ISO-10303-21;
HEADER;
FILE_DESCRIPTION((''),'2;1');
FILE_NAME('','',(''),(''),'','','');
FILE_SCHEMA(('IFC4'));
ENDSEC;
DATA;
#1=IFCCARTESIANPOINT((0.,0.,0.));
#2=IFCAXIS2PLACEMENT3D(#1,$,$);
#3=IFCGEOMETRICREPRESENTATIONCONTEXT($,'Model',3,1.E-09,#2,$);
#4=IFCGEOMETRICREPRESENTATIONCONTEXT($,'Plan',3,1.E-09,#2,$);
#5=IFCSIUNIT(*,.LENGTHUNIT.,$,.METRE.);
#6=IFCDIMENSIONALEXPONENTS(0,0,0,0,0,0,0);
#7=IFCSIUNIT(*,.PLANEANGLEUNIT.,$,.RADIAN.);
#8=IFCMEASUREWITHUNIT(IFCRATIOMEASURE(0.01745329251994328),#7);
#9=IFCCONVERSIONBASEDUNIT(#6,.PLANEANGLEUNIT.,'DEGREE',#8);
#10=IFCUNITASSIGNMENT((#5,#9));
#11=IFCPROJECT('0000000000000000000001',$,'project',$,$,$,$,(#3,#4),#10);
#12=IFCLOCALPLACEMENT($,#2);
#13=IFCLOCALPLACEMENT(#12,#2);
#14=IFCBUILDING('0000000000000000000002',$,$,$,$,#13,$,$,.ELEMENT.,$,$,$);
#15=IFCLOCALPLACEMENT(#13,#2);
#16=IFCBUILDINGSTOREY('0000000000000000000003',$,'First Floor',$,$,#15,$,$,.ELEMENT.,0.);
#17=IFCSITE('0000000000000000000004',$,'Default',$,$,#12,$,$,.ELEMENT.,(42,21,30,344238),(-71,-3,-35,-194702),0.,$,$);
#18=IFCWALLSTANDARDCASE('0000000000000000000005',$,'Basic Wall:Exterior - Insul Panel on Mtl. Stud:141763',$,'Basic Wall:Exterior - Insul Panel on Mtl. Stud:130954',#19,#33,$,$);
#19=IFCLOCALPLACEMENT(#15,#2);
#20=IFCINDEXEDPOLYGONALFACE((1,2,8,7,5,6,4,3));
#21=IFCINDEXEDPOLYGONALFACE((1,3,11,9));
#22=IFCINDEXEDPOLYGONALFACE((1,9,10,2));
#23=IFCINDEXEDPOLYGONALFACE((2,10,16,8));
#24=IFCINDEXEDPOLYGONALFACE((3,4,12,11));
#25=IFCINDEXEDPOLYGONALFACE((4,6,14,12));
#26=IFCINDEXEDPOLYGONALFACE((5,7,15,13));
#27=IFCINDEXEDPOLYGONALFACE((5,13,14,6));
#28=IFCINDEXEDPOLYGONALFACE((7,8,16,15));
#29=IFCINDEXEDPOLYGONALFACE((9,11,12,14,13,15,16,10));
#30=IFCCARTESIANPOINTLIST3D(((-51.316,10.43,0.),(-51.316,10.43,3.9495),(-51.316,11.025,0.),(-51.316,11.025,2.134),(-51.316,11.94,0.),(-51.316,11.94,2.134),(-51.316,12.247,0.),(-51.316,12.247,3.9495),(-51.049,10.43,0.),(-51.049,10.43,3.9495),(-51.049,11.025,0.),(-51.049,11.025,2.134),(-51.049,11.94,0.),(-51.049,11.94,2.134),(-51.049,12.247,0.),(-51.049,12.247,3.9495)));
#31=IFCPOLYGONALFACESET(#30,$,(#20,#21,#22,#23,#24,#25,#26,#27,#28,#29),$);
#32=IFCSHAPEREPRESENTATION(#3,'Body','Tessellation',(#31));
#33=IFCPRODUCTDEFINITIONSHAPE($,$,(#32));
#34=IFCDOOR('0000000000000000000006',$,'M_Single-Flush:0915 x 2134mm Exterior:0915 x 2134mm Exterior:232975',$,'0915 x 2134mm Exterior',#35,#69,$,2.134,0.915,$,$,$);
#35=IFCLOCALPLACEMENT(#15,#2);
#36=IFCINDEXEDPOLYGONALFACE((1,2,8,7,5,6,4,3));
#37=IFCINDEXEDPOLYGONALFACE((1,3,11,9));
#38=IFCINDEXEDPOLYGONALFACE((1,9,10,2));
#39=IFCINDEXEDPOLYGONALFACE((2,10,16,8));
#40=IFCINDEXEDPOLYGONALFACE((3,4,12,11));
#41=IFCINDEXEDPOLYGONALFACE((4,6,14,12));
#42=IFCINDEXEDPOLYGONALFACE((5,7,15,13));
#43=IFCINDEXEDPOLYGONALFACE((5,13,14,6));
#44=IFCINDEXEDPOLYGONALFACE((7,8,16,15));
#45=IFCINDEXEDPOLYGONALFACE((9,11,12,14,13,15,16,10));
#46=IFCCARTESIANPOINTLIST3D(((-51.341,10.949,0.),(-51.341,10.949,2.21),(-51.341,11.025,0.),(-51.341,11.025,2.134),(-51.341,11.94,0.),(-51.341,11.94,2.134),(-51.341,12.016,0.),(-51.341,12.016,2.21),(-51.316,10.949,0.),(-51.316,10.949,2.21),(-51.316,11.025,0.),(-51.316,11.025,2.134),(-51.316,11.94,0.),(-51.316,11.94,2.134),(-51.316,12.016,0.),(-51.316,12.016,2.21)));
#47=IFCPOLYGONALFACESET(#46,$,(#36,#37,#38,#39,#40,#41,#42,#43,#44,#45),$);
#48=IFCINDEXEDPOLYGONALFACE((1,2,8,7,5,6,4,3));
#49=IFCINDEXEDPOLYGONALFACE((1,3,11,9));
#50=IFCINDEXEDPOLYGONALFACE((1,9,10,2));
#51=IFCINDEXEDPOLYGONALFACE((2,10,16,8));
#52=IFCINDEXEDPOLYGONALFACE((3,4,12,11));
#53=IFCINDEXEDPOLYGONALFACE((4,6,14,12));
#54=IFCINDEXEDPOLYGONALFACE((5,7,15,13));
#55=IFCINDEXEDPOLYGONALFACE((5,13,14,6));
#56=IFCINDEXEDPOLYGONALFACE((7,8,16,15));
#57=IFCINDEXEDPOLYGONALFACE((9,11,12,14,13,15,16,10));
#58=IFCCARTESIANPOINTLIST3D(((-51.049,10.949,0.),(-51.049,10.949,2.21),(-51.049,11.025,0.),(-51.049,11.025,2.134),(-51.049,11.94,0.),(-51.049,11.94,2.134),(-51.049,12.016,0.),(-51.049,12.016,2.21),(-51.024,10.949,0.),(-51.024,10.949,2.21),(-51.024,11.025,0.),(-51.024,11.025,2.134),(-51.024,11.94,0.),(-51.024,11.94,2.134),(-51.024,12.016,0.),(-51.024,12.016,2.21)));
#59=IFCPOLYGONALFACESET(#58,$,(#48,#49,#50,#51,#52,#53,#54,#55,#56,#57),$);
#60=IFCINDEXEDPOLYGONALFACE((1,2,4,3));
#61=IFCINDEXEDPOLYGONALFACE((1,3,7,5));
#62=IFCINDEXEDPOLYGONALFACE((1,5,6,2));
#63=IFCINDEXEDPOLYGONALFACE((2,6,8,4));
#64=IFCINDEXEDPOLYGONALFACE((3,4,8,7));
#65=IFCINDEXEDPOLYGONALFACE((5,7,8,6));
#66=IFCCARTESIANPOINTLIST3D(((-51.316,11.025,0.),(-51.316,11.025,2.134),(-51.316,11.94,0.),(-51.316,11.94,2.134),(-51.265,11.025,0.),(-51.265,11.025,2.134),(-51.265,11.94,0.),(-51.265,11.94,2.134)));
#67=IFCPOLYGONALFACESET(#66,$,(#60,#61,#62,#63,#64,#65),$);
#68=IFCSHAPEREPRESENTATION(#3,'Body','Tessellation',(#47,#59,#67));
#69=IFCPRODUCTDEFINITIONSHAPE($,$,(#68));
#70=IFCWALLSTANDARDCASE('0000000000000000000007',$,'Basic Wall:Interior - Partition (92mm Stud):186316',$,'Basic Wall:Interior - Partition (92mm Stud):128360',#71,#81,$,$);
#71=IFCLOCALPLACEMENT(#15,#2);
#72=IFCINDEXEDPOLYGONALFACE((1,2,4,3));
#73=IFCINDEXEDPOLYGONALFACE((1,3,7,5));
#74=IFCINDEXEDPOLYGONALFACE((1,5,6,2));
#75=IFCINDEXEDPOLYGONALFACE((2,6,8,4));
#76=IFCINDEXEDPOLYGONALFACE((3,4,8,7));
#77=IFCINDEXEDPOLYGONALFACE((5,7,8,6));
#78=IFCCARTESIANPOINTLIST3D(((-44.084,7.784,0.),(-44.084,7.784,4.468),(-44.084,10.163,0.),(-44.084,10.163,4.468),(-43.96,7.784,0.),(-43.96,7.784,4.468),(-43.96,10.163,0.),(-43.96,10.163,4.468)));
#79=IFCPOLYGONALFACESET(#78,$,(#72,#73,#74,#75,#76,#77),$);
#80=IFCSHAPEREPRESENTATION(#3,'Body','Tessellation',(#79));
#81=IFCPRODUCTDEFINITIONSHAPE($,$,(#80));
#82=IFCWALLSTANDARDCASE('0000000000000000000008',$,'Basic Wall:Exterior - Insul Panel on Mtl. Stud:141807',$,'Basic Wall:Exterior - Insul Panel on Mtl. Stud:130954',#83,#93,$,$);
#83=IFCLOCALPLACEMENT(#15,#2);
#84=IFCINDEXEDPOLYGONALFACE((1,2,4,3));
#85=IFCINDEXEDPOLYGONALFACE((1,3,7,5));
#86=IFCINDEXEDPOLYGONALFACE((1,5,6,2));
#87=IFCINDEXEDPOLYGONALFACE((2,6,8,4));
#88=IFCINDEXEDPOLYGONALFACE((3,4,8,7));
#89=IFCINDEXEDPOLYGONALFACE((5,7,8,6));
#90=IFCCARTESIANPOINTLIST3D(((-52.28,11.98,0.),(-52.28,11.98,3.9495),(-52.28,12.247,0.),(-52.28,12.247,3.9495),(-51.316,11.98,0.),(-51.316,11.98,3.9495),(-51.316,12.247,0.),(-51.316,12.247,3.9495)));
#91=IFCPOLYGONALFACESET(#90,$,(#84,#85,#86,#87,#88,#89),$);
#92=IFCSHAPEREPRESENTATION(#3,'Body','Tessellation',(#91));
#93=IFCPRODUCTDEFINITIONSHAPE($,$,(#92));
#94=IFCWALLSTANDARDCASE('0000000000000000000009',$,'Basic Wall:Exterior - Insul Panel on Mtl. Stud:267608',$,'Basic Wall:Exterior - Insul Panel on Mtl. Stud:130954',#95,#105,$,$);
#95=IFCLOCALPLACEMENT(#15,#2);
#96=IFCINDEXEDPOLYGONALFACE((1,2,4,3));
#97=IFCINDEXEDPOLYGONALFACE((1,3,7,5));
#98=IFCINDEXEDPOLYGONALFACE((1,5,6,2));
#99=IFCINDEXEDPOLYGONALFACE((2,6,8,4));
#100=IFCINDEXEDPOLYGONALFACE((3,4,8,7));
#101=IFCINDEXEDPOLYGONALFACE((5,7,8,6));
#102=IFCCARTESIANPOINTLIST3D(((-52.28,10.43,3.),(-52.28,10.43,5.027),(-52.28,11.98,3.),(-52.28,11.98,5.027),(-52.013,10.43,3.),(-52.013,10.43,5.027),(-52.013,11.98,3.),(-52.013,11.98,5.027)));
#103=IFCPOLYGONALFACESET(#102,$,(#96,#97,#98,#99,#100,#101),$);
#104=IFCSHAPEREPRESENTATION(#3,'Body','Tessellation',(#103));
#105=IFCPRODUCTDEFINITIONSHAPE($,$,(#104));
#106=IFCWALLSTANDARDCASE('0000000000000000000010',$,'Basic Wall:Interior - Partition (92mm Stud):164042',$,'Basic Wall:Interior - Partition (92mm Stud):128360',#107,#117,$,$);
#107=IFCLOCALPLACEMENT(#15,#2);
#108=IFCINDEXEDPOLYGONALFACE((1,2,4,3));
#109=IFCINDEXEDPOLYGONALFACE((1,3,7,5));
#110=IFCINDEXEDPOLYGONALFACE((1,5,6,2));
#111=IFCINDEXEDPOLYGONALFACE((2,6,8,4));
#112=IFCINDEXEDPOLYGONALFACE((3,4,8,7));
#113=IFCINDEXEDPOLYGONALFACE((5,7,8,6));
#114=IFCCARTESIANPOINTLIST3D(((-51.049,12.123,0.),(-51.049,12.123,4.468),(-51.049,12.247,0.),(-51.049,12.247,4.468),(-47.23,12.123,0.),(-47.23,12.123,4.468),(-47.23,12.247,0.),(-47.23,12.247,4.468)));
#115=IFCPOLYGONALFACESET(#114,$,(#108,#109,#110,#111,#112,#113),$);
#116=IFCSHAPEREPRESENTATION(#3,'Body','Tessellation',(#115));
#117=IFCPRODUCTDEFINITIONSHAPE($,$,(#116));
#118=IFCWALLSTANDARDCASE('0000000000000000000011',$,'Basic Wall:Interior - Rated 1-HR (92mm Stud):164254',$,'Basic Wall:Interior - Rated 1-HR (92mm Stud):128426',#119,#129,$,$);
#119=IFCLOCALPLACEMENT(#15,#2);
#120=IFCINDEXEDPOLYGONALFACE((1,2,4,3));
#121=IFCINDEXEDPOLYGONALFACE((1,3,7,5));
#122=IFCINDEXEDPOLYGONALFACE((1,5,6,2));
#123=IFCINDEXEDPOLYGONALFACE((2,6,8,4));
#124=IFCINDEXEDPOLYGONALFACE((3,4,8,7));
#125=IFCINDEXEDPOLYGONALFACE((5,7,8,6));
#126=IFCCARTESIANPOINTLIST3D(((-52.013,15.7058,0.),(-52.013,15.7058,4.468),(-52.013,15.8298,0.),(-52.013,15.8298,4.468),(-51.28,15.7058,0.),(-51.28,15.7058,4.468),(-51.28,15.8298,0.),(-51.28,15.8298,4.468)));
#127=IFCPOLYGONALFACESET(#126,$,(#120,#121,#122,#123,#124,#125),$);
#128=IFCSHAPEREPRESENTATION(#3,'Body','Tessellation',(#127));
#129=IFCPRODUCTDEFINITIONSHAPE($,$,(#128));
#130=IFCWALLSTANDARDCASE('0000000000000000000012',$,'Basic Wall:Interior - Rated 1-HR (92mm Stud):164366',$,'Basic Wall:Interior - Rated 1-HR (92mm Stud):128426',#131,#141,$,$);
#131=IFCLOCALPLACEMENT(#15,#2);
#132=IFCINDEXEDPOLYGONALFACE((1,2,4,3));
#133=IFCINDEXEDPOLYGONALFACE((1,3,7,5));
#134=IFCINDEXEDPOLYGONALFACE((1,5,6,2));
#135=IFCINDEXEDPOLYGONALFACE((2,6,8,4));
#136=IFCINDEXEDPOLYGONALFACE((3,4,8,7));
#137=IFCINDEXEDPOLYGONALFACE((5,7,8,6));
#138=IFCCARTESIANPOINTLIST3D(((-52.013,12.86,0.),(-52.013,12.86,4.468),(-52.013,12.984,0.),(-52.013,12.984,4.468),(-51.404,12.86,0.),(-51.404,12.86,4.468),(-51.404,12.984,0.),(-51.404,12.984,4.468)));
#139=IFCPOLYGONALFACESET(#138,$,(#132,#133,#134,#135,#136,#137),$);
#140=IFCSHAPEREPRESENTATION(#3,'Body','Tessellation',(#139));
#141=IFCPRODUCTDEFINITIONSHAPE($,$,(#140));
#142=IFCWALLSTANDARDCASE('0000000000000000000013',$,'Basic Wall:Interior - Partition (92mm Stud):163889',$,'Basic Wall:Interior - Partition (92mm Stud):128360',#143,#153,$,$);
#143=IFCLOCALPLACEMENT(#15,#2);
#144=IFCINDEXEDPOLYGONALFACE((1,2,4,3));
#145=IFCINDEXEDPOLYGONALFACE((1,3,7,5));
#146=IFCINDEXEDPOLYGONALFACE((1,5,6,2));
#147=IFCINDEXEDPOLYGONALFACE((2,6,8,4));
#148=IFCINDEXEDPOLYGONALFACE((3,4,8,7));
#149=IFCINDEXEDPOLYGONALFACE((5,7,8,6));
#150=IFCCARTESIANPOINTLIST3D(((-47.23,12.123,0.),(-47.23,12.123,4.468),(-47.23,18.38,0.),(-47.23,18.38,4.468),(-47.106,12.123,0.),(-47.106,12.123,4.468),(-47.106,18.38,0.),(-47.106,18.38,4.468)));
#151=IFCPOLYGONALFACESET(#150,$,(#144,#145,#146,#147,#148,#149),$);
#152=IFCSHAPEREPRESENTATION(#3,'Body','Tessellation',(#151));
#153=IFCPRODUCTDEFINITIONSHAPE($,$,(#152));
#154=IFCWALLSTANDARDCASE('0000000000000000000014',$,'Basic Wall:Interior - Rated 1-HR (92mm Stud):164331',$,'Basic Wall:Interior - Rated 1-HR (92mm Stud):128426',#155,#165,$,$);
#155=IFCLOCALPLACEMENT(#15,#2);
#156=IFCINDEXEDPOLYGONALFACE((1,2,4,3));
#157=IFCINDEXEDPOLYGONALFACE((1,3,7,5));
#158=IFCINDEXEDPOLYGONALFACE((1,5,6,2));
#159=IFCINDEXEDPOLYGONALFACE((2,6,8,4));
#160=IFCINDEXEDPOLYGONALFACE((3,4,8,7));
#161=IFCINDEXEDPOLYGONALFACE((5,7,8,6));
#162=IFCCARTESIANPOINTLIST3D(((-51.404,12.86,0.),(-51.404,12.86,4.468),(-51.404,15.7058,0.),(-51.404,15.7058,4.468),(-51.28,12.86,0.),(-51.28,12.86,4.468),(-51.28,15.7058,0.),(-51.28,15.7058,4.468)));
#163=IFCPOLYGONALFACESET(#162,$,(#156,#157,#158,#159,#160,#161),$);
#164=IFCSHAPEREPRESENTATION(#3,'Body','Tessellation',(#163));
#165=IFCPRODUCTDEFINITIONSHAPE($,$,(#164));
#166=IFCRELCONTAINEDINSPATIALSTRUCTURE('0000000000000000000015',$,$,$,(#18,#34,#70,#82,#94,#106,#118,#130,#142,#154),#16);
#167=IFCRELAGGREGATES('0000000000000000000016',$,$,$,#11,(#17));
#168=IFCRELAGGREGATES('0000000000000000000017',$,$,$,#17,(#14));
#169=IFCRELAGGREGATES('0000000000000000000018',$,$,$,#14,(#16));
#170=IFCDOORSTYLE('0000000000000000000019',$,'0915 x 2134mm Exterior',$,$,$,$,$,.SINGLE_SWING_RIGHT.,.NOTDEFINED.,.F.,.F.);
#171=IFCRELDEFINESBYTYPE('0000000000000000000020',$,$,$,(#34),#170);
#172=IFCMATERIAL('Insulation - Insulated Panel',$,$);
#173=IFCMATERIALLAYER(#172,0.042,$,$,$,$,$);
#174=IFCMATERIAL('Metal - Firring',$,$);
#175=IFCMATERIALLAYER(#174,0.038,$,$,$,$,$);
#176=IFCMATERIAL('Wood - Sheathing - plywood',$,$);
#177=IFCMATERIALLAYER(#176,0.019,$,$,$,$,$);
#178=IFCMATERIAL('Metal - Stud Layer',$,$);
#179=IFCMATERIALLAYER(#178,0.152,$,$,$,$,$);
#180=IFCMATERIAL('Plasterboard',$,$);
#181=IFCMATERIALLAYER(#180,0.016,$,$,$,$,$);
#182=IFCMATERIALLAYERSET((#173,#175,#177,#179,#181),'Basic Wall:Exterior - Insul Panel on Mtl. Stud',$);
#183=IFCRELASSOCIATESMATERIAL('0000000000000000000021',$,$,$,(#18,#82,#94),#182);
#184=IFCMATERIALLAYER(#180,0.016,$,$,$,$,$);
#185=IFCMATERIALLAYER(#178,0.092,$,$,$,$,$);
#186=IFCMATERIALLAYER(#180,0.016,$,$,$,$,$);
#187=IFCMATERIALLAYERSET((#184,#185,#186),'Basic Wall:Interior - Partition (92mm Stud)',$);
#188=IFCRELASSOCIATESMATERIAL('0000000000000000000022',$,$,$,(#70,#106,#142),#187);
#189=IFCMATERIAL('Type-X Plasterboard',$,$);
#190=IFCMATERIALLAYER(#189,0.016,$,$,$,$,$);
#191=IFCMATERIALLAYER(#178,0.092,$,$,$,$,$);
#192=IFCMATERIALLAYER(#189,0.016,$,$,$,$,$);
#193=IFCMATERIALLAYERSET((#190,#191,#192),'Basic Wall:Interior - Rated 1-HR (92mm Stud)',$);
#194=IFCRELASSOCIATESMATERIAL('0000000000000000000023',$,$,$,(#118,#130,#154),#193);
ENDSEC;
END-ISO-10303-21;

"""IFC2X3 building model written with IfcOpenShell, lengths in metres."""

from ifc_helpers import new_model, entity, si_unit, converted_unit, frame, frame_2d, origin, origin_2d_with_axis, place, context, project, spatial, polyline, rectangle, outline, extrude, source, transform, mapped, material, layer, layer_set, layer_usage, type_object, type_shapes, element, fill, save


model = new_model("IFC2X3")

# Units and contexts
model_context = context("Model", 3, precision=1e-09, world=origin())
plan_context = context("Plan", 3, precision=1e-09, world=origin())
ifc_project = project(units=[si_unit("LENGTHUNIT", "METRE"), converted_unit("PLANEANGLEUNIT", "DEGREE", entity("IfcRatioMeasure", 0.01745329251994328), si_unit("PLANEANGLEUNIT", "RADIAN"), dimensions=[0, 0, 0, 0, 0, 0, 0])], contexts=[model_context, plan_context])

# Site, building, storey
site_placement = place(None, origin())
site = spatial("IfcSite", under=ifc_project, at=site_placement, Name="Default", CompositionType="ELEMENT", RefLatitude=(42, 21, 30, 344238), RefLongitude=(-71, -3, -35, -194702), RefElevation=0.0)
building_placement = place(site_placement, origin())
building = spatial("IfcBuilding", under=site, at=building_placement, CompositionType="ELEMENT")
storey_placement = place(building_placement, origin())
storey = spatial("IfcBuildingStorey", under=building, at=storey_placement, Name="First Floor", CompositionType="ELEMENT", Elevation=0.0)

# Shared definitions
ifc_material_1 = material(Name="Insulation - Insulated Panel")
ifc_layer_1 = layer(ifc_material_1, 0.042)
ifc_material_2 = material(Name="Metal - Firring")
ifc_layer_2 = layer(ifc_material_2, 0.038)
ifc_material_3 = material(Name="Wood - Sheathing - plywood")
ifc_layer_3 = layer(ifc_material_3, 0.019)
ifc_material_4 = material(Name="Metal - Stud Layer")
ifc_layer_4 = layer(ifc_material_4, 0.152)
ifc_material_5 = material(Name="Plasterboard")
ifc_layer_5 = layer(ifc_material_5, 0.016)
ifc_layer_set_1 = layer_set([ifc_layer_1, ifc_layer_2, ifc_layer_3, ifc_layer_4, ifc_layer_5], Name="Basic Wall:Exterior - Insul Panel on Mtl. Stud")
ifc_layer_usage_1 = layer_usage(ifc_layer_set_1, "AXIS2", "NEGATIVE", 0.1335)

# Shared definitions
ifc_layer_6 = layer(ifc_material_5, 0.016)
ifc_layer_7 = layer(ifc_material_4, 0.092)
ifc_layer_8 = layer(ifc_material_5, 0.016)
ifc_layer_set_2 = layer_set([ifc_layer_6, ifc_layer_7, ifc_layer_8], Name="Basic Wall:Interior - Partition (92mm Stud)")
ifc_layer_usage_2 = layer_usage(ifc_layer_set_2, "AXIS2", "NEGATIVE", 0.062)

# Wall, opening, door
wall_1_placement = place(storey_placement, frame((-51.1825, 10.43, 0.0), z_axis=(0.0, 0.0, 1.0), x_axis=(0.0, 1.0, 0.0)))
wall_1 = element("IfcWallStandardCase", 1, at=wall_1_placement, inside=storey, material=ifc_layer_usage_1, Name="Basic Wall:Exterior - Insul Panel on Mtl. Stud:141763", ObjectType="Basic Wall:Exterior - Insul Panel on Mtl. Stud:130954", context=model_context, shape_type="SweptSolid", body=[
    extrude(rectangle(XDim=1.817, YDim=0.267, at=frame_2d((0.9085, 0.0), x_axis=(-1.0, 0.0))), origin(), (0.0, 0.0, 1.0), 3.9495),
])
opening_1_placement = place(wall_1_placement, frame((0.595, -0.1335, 0.0)))
opening_1 = element("IfcOpeningElement", 2, at=opening_1_placement, cuts=wall_1, ObjectType="Opening", context=model_context, shape_type="SweptSolid", body=[
    extrude(rectangle(XDim=0.915, YDim=2.134, at=frame_2d((1.067, 0.4575), x_axis=(0.0, 1.0))), frame((0.0, 0.0, 0.0), z_axis=(0.0, 1.0, 0.0), x_axis=(0.0, 0.0, 1.0)), (0.0, 0.0, 1.0), 0.267),
])
door_style_1 = type_object("IfcDoorStyle", Name="0915 x 2134mm Exterior", ConstructionType="NOTDEFINED", OperationType="SINGLE_SWING_RIGHT", ParameterTakesPrecedence=False, Sizeable=False)
shared_shape_1 = source(origin(), model_context, "Body", "SweptSolid", [
    extrude(outline(polyline([(-0.5335, -1.124), (0.5335, -1.124), (0.5335, 1.086), (0.4575, 1.086), (0.4575, -1.048), (-0.4575, -1.048), (-0.4575, 1.086), (-0.5335, 1.086), (-0.5335, -1.124)])), frame((0.4575, 0.267, 1.086), z_axis=(0.0, 1.0, 0.0), x_axis=(1.0, 0.0, 0.0)), (0.0, 0.0, 1.0), 0.025),
    extrude(outline(polyline([(-1.124, -0.5335), (1.086, -0.5335), (1.086, -0.4575), (-1.048, -0.4575), (-1.048, 0.4575), (1.086, 0.4575), (1.086, 0.5335), (-1.124, 0.5335), (-1.124, -0.5335)])), frame((0.4575, -0.025, 1.086), z_axis=(0.0, 1.0, 0.0), x_axis=(0.0, 0.0, -1.0)), (0.0, 0.0, 1.0), 0.025),
    extrude(rectangle(XDim=0.051, YDim=0.915, at=origin_2d_with_axis()), frame((0.4575, 0.2415, 0.0), z_axis=(0.0, 0.0, 1.0), x_axis=(0.0, 1.0, 0.0)), (0.0, 0.0, 1.0), 2.134),
])
type_shapes(door_style_1, [shared_shape_1])
door_1_placement = place(opening_1_placement, origin())
door_1 = element("IfcDoor", 3, at=door_1_placement, inside=storey, type_object=door_style_1, Name="M_Single-Flush:0915 x 2134mm Exterior:0915 x 2134mm Exterior:232975", ObjectType="0915 x 2134mm Exterior", OverallHeight=2.134, OverallWidth=0.915, context=model_context, shape_type="MappedRepresentation", body=[
    mapped(shared_shape_1, transform((0.0, 0.0, 0.0), scale=1.0)),
])
fill(opening_1, door_1)

# Walls
wall_2_placement = place(storey_placement, frame((-44.022, 10.163, 0.0), z_axis=(0.0, 0.0, 1.0), x_axis=(0.0, -1.0, 0.0)))
element("IfcWallStandardCase", 4, at=wall_2_placement, inside=storey, material=ifc_layer_usage_2, Name="Basic Wall:Interior - Partition (92mm Stud):186316", ObjectType="Basic Wall:Interior - Partition (92mm Stud):128360", context=model_context, shape_type="SweptSolid", body=[
    extrude(rectangle(XDim=2.379, YDim=0.124, at=frame_2d((1.1895, 0.0), x_axis=(-1.0, 0.0))), origin(), (0.0, 0.0, 1.0), 4.468),
])
wall_3_placement = place(storey_placement, frame((-51.316, 12.1135, 0.0), z_axis=(0.0, 0.0, 1.0), x_axis=(-1.0, 0.0, 0.0)))
element("IfcWallStandardCase", 5, at=wall_3_placement, inside=storey, material=ifc_layer_usage_1, Name="Basic Wall:Exterior - Insul Panel on Mtl. Stud:141807", ObjectType="Basic Wall:Exterior - Insul Panel on Mtl. Stud:130954", context=model_context, shape_type="SweptSolid", body=[
    extrude(rectangle(XDim=0.964, YDim=0.267, at=frame_2d((0.482, 0.0), x_axis=(-1.0, 0.0))), origin(), (0.0, 0.0, 1.0), 3.9495),
])
wall_4_placement = place(storey_placement, frame((-52.1465, 10.2965, 3.0), z_axis=(0.0, 0.0, 1.0), x_axis=(0.0, 1.0, 0.0)))
element("IfcWallStandardCase", 6, at=wall_4_placement, inside=storey, material=ifc_layer_usage_1, Name="Basic Wall:Exterior - Insul Panel on Mtl. Stud:267608", ObjectType="Basic Wall:Exterior - Insul Panel on Mtl. Stud:130954", context=model_context, shape_type="SweptSolid", body=[
    extrude(rectangle(XDim=1.55, YDim=0.267, at=frame_2d((0.9085, 0.0), x_axis=(-1.0, 0.0))), origin(), (0.0, 0.0, 1.0), 2.027),
])
wall_5_placement = place(storey_placement, frame((-51.049, 12.185, 0.0)))
element("IfcWallStandardCase", 7, at=wall_5_placement, inside=storey, material=ifc_layer_usage_2, Name="Basic Wall:Interior - Partition (92mm Stud):164042", ObjectType="Basic Wall:Interior - Partition (92mm Stud):128360", context=model_context, shape_type="SweptSolid", body=[
    extrude(rectangle(XDim=3.819, YDim=0.124, at=frame_2d((1.9095, 0.0), x_axis=(-1.0, 0.0))), origin(), (0.0, 0.0, 1.0), 4.468),
])
ifc_material_6 = material(Name="Type-X Plasterboard")
ifc_layer_9 = layer(ifc_material_6, 0.016)
ifc_layer_10 = layer(ifc_material_4, 0.092)
ifc_layer_11 = layer(ifc_material_6, 0.016)
ifc_layer_set_3 = layer_set([ifc_layer_9, ifc_layer_10, ifc_layer_11], Name="Basic Wall:Interior - Rated 1-HR (92mm Stud)")
ifc_layer_usage_3 = layer_usage(ifc_layer_set_3, "AXIS2", "NEGATIVE", 0.062)
wall_6_placement = place(storey_placement, frame((-52.013, 15.7678, 0.0)))
element("IfcWallStandardCase", 8, at=wall_6_placement, inside=storey, material=ifc_layer_usage_3, Name="Basic Wall:Interior - Rated 1-HR (92mm Stud):164254", ObjectType="Basic Wall:Interior - Rated 1-HR (92mm Stud):128426", context=model_context, shape_type="SweptSolid", body=[
    extrude(rectangle(XDim=0.733, YDim=0.124, at=frame_2d((0.3665, 0.0), x_axis=(-1.0, 0.0))), origin(), (0.0, 0.0, 1.0), 4.468),
])
wall_7_placement = place(storey_placement, frame((-51.404, 12.922, 0.0), z_axis=(0.0, 0.0, 1.0), x_axis=(-1.0, 0.0, 0.0)))
element("IfcWallStandardCase", 9, at=wall_7_placement, inside=storey, material=ifc_layer_usage_3, Name="Basic Wall:Interior - Rated 1-HR (92mm Stud):164366", ObjectType="Basic Wall:Interior - Rated 1-HR (92mm Stud):128426", context=model_context, shape_type="SweptSolid", body=[
    extrude(rectangle(XDim=0.609, YDim=0.124, at=frame_2d((0.3045, 0.0), x_axis=(-1.0, 0.0))), origin(), (0.0, 0.0, 1.0), 4.468),
])
wall_8_placement = place(storey_placement, frame((-47.168, 12.123, 0.0), z_axis=(0.0, 0.0, 1.0), x_axis=(0.0, 1.0, 0.0)))
element("IfcWallStandardCase", 10, at=wall_8_placement, inside=storey, material=ifc_layer_usage_2, Name="Basic Wall:Interior - Partition (92mm Stud):163889", ObjectType="Basic Wall:Interior - Partition (92mm Stud):128360", context=model_context, shape_type="SweptSolid", body=[
    extrude(rectangle(XDim=6.257, YDim=0.124, at=frame_2d((3.1285, 0.0), x_axis=(-1.0, 0.0))), origin(), (0.0, 0.0, 1.0), 4.468),
])
wall_9_placement = place(storey_placement, frame((-51.342, 15.7058, 0.0), z_axis=(0.0, 0.0, 1.0), x_axis=(0.0, -1.0, 0.0)))
element("IfcWallStandardCase", 11, at=wall_9_placement, inside=storey, material=ifc_layer_usage_3, Name="Basic Wall:Interior - Rated 1-HR (92mm Stud):164331", ObjectType="Basic Wall:Interior - Rated 1-HR (92mm Stud):128426", context=model_context, shape_type="SweptSolid", body=[
    extrude(rectangle(XDim=2.8458, YDim=0.124, at=frame_2d((1.4229, 0.0), x_axis=(-1.0, 0.0))), origin(), (0.0, 0.0, 1.0), 4.468),
])

save(model, "model.ifc")
